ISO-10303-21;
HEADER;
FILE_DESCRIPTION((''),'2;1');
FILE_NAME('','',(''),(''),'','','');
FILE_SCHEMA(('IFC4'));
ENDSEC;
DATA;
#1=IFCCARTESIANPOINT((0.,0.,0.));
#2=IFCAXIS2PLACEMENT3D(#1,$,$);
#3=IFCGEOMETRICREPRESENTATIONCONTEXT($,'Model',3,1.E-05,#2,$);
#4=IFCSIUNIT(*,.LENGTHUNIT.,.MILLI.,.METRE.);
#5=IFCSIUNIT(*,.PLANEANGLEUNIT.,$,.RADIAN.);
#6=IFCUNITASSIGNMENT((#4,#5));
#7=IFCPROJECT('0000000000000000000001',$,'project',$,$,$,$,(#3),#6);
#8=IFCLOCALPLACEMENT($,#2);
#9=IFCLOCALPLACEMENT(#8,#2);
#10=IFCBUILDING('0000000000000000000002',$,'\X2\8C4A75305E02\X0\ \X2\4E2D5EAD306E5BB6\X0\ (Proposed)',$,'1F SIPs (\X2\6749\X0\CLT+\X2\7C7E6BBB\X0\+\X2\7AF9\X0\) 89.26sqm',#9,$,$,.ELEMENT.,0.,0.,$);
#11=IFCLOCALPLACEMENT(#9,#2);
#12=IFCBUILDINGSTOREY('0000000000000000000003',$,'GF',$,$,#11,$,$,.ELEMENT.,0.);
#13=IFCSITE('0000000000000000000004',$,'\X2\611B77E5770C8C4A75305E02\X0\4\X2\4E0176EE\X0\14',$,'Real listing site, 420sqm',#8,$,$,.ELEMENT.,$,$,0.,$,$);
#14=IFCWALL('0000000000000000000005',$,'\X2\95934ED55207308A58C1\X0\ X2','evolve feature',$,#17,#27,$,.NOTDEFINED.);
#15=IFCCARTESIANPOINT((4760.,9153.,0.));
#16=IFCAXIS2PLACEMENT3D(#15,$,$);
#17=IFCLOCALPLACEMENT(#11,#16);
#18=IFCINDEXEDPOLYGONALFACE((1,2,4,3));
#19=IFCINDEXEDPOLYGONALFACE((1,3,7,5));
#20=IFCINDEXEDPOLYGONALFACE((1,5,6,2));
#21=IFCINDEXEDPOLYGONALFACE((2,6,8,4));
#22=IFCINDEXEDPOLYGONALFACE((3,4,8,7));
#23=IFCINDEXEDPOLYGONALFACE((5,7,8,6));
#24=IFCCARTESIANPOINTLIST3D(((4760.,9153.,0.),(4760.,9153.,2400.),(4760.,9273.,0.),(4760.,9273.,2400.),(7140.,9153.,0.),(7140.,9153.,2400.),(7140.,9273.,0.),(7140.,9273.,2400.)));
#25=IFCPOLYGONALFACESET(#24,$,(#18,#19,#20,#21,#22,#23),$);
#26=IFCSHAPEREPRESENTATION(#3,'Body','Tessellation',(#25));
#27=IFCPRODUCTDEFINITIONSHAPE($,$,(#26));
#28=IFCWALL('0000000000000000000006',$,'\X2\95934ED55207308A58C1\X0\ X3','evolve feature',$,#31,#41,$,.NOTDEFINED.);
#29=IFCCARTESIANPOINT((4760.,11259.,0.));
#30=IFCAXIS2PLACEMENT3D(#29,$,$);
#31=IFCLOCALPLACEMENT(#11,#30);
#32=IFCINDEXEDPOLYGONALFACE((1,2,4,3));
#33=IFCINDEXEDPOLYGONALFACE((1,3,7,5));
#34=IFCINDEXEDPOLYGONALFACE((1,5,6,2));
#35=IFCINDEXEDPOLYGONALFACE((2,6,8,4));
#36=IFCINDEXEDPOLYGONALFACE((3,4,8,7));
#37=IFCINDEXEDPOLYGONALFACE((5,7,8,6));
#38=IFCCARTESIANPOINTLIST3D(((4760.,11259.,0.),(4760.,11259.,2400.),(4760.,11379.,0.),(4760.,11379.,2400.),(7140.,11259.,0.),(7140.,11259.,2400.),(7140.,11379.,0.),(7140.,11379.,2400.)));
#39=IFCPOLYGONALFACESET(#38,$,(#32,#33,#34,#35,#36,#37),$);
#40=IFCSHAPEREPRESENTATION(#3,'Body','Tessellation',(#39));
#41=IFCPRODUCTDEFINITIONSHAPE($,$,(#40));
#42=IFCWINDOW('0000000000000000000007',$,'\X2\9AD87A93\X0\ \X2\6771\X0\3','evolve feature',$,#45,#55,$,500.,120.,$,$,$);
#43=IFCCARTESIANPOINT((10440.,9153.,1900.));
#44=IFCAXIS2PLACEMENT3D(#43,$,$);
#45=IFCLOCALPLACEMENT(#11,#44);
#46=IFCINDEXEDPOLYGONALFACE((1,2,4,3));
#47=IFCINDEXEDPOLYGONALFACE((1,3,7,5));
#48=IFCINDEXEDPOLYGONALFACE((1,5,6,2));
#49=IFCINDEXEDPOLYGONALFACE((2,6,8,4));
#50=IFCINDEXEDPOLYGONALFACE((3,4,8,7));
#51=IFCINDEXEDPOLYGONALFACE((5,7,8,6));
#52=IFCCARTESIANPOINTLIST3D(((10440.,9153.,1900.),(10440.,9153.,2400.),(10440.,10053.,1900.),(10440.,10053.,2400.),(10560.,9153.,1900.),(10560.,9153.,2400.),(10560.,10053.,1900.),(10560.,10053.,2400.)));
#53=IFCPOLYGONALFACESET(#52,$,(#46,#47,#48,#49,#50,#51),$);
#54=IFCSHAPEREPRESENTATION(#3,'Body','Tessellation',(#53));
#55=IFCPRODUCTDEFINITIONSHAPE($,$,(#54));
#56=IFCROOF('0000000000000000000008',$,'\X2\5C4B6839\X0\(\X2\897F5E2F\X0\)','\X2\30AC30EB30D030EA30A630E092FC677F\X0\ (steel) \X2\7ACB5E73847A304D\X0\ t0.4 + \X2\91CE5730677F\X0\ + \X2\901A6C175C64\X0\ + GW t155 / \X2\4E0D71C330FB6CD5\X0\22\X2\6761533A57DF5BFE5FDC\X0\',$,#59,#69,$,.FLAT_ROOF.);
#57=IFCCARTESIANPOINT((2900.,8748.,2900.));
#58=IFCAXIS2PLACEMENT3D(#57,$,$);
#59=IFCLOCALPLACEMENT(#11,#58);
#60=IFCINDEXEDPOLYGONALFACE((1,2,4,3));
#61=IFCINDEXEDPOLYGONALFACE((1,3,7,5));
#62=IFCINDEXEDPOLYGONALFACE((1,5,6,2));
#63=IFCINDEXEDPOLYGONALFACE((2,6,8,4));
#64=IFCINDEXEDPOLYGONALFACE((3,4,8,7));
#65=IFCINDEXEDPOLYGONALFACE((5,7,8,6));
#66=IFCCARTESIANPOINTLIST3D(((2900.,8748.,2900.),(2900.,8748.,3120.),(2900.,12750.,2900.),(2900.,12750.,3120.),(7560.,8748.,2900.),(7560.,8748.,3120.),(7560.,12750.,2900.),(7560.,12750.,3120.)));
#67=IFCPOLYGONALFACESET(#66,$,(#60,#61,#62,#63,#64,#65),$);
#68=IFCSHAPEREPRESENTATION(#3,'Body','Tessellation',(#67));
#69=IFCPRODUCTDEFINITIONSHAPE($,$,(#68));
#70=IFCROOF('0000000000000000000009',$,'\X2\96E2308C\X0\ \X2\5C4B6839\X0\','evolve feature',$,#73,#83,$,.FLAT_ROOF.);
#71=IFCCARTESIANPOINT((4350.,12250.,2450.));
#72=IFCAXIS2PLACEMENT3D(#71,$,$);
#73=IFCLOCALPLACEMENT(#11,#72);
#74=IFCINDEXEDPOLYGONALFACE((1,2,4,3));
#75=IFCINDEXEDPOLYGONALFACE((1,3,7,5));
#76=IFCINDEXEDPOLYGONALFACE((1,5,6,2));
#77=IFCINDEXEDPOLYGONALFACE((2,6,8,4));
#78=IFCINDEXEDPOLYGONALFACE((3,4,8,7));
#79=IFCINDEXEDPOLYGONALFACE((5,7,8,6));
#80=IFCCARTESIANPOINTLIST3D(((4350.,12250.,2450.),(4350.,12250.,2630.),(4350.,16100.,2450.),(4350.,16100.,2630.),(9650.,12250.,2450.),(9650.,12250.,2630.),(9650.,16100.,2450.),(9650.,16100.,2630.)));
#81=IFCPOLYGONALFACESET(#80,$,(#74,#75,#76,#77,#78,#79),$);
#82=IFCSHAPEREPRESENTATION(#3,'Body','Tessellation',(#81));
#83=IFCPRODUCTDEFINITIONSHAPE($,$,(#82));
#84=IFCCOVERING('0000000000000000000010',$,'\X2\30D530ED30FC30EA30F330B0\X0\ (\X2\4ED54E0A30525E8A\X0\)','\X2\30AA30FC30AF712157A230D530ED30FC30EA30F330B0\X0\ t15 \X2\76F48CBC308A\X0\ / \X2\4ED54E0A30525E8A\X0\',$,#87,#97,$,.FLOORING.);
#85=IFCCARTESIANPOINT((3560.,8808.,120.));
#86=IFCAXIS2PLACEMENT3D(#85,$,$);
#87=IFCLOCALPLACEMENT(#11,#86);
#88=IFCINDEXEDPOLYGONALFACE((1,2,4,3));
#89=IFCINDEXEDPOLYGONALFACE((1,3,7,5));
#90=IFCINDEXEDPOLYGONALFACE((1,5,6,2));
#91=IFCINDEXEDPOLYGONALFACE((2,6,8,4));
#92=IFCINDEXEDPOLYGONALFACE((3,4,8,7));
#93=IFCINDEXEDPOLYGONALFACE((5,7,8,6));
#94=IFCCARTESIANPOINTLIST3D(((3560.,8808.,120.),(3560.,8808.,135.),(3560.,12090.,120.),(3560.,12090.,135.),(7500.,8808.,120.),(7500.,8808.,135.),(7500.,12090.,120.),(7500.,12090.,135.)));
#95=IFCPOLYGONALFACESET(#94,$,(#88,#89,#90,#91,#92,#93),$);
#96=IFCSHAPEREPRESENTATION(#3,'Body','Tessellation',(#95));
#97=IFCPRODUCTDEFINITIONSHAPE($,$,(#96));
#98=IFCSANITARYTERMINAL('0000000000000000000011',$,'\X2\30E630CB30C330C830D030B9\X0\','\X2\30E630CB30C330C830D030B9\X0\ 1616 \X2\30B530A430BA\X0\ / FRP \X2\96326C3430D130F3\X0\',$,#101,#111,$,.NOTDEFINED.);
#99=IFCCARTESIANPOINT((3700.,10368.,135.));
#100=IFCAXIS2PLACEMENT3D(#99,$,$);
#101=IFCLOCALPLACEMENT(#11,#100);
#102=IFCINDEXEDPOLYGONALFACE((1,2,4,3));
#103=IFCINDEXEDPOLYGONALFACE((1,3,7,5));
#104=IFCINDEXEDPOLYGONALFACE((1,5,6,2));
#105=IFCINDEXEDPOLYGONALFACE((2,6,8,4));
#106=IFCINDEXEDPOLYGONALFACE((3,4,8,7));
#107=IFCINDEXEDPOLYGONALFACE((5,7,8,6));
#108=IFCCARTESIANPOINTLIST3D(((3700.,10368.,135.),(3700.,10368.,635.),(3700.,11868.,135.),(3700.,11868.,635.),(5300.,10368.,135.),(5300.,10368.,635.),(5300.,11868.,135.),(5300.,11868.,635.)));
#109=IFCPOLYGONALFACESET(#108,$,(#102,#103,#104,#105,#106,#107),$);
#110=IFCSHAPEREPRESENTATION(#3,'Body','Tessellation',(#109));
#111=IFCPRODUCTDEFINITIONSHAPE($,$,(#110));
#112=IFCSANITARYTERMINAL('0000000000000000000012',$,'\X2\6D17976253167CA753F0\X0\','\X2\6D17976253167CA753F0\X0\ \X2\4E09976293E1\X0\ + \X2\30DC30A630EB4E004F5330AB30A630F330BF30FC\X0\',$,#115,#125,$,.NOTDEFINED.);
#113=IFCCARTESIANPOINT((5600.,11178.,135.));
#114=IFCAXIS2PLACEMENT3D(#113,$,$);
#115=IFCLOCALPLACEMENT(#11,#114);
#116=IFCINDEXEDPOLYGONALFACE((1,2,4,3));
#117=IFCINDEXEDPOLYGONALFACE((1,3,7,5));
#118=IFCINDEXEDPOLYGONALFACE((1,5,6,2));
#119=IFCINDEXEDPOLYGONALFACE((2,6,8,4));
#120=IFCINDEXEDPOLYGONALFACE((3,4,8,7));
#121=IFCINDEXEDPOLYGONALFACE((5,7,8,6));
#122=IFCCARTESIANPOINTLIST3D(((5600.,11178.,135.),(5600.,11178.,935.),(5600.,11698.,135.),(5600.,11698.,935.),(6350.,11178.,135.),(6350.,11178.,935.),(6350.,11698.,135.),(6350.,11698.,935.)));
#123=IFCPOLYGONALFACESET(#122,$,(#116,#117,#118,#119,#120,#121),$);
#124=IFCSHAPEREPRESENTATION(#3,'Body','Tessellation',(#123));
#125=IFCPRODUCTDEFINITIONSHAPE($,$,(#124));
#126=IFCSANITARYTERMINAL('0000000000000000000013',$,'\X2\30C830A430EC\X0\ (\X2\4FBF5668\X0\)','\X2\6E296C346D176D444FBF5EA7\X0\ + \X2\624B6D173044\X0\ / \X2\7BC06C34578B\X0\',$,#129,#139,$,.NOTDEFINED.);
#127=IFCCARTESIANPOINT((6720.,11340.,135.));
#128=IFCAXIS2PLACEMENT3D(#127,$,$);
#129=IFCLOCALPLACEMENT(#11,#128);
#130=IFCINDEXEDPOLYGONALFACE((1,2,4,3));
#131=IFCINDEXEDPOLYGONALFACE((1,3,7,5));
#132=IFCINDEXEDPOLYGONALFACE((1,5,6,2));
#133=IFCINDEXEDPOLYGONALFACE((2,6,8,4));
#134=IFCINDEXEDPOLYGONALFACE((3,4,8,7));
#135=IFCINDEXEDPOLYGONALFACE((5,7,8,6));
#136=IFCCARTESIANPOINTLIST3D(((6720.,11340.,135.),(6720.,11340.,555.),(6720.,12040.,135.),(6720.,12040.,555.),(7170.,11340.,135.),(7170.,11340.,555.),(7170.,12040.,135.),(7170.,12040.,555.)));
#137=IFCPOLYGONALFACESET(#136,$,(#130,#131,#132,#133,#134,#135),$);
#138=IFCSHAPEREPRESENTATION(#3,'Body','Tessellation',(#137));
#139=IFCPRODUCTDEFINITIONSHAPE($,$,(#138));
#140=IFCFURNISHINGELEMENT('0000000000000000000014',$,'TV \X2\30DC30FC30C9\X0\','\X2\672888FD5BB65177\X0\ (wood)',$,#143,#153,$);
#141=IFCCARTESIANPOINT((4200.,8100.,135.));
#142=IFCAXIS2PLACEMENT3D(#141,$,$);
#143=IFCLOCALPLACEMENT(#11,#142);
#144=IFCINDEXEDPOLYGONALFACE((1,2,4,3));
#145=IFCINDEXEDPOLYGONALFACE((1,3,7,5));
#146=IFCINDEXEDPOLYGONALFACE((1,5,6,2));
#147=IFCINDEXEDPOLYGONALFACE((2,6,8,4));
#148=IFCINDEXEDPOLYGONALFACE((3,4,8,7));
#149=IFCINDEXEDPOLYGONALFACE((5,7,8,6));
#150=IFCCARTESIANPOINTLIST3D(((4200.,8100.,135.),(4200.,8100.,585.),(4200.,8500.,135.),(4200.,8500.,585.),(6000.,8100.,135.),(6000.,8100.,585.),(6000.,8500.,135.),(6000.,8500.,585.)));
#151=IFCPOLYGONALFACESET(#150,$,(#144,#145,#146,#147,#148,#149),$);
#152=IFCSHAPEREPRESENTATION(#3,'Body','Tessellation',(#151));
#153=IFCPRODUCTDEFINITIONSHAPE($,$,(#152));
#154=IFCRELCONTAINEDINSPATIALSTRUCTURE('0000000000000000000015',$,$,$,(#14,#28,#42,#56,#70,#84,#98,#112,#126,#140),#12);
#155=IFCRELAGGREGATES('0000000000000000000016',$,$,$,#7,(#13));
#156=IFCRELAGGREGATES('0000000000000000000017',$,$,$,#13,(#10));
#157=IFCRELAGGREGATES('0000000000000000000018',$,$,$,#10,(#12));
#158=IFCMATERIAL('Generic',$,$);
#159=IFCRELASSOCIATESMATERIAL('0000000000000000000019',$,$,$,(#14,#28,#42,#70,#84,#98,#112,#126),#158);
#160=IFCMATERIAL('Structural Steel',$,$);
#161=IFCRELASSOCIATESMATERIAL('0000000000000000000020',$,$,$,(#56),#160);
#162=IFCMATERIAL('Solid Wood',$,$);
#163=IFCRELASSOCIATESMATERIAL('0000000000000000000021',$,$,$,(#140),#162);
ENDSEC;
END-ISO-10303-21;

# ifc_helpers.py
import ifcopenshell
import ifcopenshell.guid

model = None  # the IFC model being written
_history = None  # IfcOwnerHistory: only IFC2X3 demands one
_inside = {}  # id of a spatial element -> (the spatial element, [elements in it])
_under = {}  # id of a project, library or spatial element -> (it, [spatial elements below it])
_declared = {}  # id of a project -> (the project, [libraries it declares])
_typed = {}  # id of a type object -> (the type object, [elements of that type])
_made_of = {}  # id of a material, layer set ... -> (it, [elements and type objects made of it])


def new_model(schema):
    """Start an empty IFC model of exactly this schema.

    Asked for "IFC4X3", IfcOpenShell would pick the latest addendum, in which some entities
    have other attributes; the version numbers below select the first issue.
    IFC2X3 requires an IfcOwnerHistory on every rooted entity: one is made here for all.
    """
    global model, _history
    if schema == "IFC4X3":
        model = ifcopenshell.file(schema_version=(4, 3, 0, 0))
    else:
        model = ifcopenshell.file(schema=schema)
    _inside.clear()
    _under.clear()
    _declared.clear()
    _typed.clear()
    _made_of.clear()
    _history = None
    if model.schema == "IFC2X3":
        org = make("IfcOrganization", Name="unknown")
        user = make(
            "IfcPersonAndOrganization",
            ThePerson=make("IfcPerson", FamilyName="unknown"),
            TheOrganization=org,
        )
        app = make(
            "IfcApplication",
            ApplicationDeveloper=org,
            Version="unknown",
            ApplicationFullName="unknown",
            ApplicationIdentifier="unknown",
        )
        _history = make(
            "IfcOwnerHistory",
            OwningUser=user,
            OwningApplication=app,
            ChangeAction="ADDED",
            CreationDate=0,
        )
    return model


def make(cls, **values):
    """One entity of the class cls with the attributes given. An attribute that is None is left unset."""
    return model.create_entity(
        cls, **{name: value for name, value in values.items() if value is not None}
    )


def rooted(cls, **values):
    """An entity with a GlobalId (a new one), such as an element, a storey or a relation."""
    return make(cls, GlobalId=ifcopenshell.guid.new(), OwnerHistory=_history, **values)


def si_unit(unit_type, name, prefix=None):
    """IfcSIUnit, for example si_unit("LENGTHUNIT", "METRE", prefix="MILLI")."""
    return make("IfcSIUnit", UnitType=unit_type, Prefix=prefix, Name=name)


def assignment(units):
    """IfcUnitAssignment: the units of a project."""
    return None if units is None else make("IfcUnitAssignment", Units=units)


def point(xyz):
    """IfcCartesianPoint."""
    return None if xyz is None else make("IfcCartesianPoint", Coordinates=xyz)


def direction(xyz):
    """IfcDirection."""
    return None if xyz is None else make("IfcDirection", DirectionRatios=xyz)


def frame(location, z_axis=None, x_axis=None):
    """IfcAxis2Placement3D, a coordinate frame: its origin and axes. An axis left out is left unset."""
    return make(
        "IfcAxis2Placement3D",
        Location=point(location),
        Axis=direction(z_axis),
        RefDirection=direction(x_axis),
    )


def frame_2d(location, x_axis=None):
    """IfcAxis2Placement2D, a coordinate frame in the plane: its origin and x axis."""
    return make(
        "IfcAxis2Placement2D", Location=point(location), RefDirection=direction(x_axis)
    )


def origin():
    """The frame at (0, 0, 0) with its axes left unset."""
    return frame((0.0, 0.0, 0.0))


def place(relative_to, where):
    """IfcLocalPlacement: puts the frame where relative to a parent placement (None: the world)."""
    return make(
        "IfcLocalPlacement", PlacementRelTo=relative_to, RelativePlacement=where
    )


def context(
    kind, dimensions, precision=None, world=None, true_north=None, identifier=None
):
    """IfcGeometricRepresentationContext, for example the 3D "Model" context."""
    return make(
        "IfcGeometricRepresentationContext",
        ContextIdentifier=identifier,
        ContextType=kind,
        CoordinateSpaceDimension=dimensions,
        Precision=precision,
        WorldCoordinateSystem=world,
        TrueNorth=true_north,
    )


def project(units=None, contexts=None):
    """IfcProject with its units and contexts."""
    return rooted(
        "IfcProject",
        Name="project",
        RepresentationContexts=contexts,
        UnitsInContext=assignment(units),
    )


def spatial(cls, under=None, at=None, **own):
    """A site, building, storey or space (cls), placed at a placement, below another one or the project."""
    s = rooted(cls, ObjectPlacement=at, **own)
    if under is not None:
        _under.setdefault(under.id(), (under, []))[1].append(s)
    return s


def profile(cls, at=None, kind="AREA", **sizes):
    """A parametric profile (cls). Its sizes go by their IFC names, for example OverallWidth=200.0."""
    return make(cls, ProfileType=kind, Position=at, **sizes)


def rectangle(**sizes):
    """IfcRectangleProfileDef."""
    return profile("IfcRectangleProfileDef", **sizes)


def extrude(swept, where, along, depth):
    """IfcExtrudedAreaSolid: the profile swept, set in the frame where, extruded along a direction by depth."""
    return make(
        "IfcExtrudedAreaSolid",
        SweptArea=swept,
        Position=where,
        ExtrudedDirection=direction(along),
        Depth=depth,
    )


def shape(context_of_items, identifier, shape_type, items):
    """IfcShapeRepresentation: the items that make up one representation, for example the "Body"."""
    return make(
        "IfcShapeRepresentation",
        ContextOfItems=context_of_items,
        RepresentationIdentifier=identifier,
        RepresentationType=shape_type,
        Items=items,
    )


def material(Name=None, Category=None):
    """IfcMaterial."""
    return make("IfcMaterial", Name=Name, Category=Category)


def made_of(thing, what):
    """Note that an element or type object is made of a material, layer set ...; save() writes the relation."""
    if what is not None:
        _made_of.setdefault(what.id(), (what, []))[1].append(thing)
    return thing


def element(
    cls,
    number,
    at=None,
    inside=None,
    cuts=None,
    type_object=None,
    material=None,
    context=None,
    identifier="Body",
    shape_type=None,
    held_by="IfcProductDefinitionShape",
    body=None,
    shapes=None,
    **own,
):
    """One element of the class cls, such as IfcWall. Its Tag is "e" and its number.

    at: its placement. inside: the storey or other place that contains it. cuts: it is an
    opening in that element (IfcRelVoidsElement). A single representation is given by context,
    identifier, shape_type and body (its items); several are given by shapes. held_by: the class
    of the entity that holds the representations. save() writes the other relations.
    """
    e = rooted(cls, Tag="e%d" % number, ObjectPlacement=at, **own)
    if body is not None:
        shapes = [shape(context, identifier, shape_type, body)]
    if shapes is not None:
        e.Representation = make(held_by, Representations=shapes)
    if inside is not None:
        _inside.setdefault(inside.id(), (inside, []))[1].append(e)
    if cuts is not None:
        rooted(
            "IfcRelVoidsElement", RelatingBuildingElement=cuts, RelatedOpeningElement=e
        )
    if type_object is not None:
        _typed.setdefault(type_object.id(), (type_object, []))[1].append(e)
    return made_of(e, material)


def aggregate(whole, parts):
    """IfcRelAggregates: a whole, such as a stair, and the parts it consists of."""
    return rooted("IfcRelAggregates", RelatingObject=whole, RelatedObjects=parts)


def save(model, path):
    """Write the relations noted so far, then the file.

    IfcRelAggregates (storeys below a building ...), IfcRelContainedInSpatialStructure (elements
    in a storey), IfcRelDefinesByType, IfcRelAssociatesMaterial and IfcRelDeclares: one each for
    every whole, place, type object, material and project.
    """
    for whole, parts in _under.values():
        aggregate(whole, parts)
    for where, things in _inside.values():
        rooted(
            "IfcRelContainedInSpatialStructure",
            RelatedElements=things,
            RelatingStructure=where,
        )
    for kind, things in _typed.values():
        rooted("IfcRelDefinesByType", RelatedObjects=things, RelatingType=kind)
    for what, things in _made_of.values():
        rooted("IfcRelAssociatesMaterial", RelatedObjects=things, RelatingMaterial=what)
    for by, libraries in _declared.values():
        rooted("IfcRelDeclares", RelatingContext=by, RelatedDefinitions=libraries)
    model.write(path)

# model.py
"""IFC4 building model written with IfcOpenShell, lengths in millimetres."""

from ifc_helpers import new_model, si_unit, frame, frame_2d, origin, place, context, project, spatial, rectangle, extrude, material, element, save


model = new_model("IFC4")

# Units and contexts
model_context = context("Model", 3, precision=1e-05, world=origin())
ifc_project = project(units=[si_unit("LENGTHUNIT", "METRE", prefix="MILLI"), si_unit("PLANEANGLEUNIT", "RADIAN")], contexts=[model_context])

# Site, building, storey
site_placement = place(None, origin())
site = spatial("IfcSite", under=ifc_project, at=site_placement, Name="愛知県豊田市4丁目14", ObjectType="Real listing site, 420sqm", CompositionType="ELEMENT", RefElevation=0.0)
building_placement = place(site_placement, origin())
building = spatial("IfcBuilding", under=site, at=building_placement, Name="豊田市 中庭の家 (Proposed)", ObjectType="1F SIPs (杉CLT+籾殻+竹) 89.26sqm", CompositionType="ELEMENT", ElevationOfRefHeight=0.0, ElevationOfTerrain=0.0)
storey_placement = place(building_placement, origin())
storey = spatial("IfcBuildingStorey", under=building, at=storey_placement, Name="GF", CompositionType="ELEMENT", Elevation=0.0)

# Shared definitions
ifc_material_1 = material(Name="Solid Wood")
ifc_material_2 = material(Name="Generic")

# Walls
wall_1_placement = place(storey_placement, frame((4760.0, 9153.0, 0.0)))
element("IfcWall", 1, at=wall_1_placement, inside=storey, material=ifc_material_2, Name="間仕切り壁 X2", Description="evolve feature", PredefinedType="NOTDEFINED", context=model_context, shape_type="SweptSolid", body=[
    extrude(rectangle(XDim=2380.0, YDim=120.0, at=frame_2d((1190.0, 60.0))), frame((4760.0, 9153.0, 0.0)), (0.0, 0.0, 1.0), 2400.0),
])
wall_2_placement = place(storey_placement, frame((4760.0, 11259.0, 0.0)))
element("IfcWall", 2, at=wall_2_placement, inside=storey, material=ifc_material_2, Name="間仕切り壁 X3", Description="evolve feature", PredefinedType="NOTDEFINED", context=model_context, shape_type="SweptSolid", body=[
    extrude(rectangle(XDim=2380.0, YDim=120.0, at=frame_2d((1190.0, 60.0))), frame((4760.0, 11259.0, 0.0)), (0.0, 0.0, 1.0), 2400.0),
])

# Window
window_1_placement = place(storey_placement, frame((10440.0, 9153.0, 1900.0)))
element("IfcWindow", 3, at=window_1_placement, inside=storey, material=ifc_material_2, Name="高窓 東3", Description="evolve feature", OverallHeight=500.0, OverallWidth=120.0, context=model_context, shape_type="SweptSolid", body=[
    extrude(rectangle(XDim=120.0, YDim=900.0, at=frame_2d((60.0, 450.0))), frame((10440.0, 9153.0, 1900.0)), (0.0, 0.0, 1.0), 500.0),
])

# Roofs
ifc_material_3 = material(Name="Structural Steel")
roof_1_placement = place(storey_placement, frame((2900.0, 8748.0, 2900.0)))
element("IfcRoof", 4, at=roof_1_placement, inside=storey, material=ifc_material_3, Name="屋根(西帯)", Description="ガルバリウム鋼板 (steel) 立平葺き t0.4 + 野地板 + 通気層 + GW t155 / 不燃・法22条区域対応", PredefinedType="FLAT_ROOF", context=model_context, shape_type="SweptSolid", body=[
    extrude(rectangle(XDim=4660.0, YDim=4002.0, at=frame_2d((2330.0, 2001.0))), frame((2900.0, 8748.0, 2900.0)), (0.0, 0.0, 1.0), 220.0),
])
roof_2_placement = place(storey_placement, frame((4350.0, 12250.0, 2450.0)))
element("IfcRoof", 5, at=roof_2_placement, inside=storey, material=ifc_material_2, Name="離れ 屋根", Description="evolve feature", PredefinedType="FLAT_ROOF", context=model_context, shape_type="SweptSolid", body=[
    extrude(rectangle(XDim=5300.0, YDim=3850.0, at=frame_2d((2650.0, 1925.0))), frame((4350.0, 12250.0, 2450.0)), (0.0, 0.0, 1.0), 180.0),
])

# Covering
covering_placement = place(storey_placement, frame((3560.0, 8808.0, 120.0)))
element("IfcCovering", 6, at=covering_placement, inside=storey, material=ifc_material_2, Name="フローリング (仕上げ床)", Description="オーク無垢フローリング t15 直貼り / 仕上げ床", PredefinedType="FLOORING", context=model_context, shape_type="SweptSolid", body=[
    extrude(rectangle(XDim=3940.0, YDim=3282.0, at=frame_2d((1970.0, 1641.0))), frame((3560.0, 8808.0, 120.0)), (0.0, 0.0, 1.0), 15.0),
])

# Sanitary terminals
sanitary_terminal_1_placement = place(storey_placement, frame((3700.0, 10368.0, 135.0)))
element("IfcSanitaryTerminal", 7, at=sanitary_terminal_1_placement, inside=storey, material=ifc_material_2, Name="ユニットバス", Description="ユニットバス 1616 サイズ / FRP 防水パン", PredefinedType="NOTDEFINED", context=model_context, shape_type="SweptSolid", body=[
    extrude(rectangle(XDim=1600.0, YDim=1500.0, at=frame_2d((800.0, 750.0))), frame((3700.0, 10368.0, 135.0)), (0.0, 0.0, 1.0), 500.0),
])
sanitary_terminal_2_placement = place(storey_placement, frame((5600.0, 11178.0, 135.0)))
element("IfcSanitaryTerminal", 8, at=sanitary_terminal_2_placement, inside=storey, material=ifc_material_2, Name="洗面化粧台", Description="洗面化粧台 三面鏡 + ボウル一体カウンター", PredefinedType="NOTDEFINED", context=model_context, shape_type="SweptSolid", body=[
    extrude(rectangle(XDim=750.0, YDim=520.0, at=frame_2d((375.0, 260.0))), frame((5600.0, 11178.0, 135.0)), (0.0, 0.0, 1.0), 800.0),
])
sanitary_terminal_3_placement = place(storey_placement, frame((6720.0, 11340.0, 135.0)))
element("IfcSanitaryTerminal", 9, at=sanitary_terminal_3_placement, inside=storey, material=ifc_material_2, Name="トイレ (便器)", Description="温水洗浄便座 + 手洗い / 節水型", PredefinedType="NOTDEFINED", context=model_context, shape_type="SweptSolid", body=[
    extrude(rectangle(XDim=450.0, YDim=700.0, at=frame_2d((225.0, 350.0))), frame((6720.0, 11340.0, 135.0)), (0.0, 0.0, 1.0), 420.0),
])

# Furnishing element
furnishing_placement = place(storey_placement, frame((4200.0, 8100.0, 135.0)))
element("IfcFurnishingElement", 10, at=furnishing_placement, inside=storey, material=ifc_material_1, Name="TV ボード", Description="木製家具 (wood)", context=model_context, shape_type="SweptSolid", body=[
    extrude(rectangle(XDim=1800.0, YDim=400.0, at=frame_2d((900.0, 200.0))), frame((4200.0, 8100.0, 135.0)), (0.0, 0.0, 1.0), 450.0),
])

save(model, "model.ifc")
